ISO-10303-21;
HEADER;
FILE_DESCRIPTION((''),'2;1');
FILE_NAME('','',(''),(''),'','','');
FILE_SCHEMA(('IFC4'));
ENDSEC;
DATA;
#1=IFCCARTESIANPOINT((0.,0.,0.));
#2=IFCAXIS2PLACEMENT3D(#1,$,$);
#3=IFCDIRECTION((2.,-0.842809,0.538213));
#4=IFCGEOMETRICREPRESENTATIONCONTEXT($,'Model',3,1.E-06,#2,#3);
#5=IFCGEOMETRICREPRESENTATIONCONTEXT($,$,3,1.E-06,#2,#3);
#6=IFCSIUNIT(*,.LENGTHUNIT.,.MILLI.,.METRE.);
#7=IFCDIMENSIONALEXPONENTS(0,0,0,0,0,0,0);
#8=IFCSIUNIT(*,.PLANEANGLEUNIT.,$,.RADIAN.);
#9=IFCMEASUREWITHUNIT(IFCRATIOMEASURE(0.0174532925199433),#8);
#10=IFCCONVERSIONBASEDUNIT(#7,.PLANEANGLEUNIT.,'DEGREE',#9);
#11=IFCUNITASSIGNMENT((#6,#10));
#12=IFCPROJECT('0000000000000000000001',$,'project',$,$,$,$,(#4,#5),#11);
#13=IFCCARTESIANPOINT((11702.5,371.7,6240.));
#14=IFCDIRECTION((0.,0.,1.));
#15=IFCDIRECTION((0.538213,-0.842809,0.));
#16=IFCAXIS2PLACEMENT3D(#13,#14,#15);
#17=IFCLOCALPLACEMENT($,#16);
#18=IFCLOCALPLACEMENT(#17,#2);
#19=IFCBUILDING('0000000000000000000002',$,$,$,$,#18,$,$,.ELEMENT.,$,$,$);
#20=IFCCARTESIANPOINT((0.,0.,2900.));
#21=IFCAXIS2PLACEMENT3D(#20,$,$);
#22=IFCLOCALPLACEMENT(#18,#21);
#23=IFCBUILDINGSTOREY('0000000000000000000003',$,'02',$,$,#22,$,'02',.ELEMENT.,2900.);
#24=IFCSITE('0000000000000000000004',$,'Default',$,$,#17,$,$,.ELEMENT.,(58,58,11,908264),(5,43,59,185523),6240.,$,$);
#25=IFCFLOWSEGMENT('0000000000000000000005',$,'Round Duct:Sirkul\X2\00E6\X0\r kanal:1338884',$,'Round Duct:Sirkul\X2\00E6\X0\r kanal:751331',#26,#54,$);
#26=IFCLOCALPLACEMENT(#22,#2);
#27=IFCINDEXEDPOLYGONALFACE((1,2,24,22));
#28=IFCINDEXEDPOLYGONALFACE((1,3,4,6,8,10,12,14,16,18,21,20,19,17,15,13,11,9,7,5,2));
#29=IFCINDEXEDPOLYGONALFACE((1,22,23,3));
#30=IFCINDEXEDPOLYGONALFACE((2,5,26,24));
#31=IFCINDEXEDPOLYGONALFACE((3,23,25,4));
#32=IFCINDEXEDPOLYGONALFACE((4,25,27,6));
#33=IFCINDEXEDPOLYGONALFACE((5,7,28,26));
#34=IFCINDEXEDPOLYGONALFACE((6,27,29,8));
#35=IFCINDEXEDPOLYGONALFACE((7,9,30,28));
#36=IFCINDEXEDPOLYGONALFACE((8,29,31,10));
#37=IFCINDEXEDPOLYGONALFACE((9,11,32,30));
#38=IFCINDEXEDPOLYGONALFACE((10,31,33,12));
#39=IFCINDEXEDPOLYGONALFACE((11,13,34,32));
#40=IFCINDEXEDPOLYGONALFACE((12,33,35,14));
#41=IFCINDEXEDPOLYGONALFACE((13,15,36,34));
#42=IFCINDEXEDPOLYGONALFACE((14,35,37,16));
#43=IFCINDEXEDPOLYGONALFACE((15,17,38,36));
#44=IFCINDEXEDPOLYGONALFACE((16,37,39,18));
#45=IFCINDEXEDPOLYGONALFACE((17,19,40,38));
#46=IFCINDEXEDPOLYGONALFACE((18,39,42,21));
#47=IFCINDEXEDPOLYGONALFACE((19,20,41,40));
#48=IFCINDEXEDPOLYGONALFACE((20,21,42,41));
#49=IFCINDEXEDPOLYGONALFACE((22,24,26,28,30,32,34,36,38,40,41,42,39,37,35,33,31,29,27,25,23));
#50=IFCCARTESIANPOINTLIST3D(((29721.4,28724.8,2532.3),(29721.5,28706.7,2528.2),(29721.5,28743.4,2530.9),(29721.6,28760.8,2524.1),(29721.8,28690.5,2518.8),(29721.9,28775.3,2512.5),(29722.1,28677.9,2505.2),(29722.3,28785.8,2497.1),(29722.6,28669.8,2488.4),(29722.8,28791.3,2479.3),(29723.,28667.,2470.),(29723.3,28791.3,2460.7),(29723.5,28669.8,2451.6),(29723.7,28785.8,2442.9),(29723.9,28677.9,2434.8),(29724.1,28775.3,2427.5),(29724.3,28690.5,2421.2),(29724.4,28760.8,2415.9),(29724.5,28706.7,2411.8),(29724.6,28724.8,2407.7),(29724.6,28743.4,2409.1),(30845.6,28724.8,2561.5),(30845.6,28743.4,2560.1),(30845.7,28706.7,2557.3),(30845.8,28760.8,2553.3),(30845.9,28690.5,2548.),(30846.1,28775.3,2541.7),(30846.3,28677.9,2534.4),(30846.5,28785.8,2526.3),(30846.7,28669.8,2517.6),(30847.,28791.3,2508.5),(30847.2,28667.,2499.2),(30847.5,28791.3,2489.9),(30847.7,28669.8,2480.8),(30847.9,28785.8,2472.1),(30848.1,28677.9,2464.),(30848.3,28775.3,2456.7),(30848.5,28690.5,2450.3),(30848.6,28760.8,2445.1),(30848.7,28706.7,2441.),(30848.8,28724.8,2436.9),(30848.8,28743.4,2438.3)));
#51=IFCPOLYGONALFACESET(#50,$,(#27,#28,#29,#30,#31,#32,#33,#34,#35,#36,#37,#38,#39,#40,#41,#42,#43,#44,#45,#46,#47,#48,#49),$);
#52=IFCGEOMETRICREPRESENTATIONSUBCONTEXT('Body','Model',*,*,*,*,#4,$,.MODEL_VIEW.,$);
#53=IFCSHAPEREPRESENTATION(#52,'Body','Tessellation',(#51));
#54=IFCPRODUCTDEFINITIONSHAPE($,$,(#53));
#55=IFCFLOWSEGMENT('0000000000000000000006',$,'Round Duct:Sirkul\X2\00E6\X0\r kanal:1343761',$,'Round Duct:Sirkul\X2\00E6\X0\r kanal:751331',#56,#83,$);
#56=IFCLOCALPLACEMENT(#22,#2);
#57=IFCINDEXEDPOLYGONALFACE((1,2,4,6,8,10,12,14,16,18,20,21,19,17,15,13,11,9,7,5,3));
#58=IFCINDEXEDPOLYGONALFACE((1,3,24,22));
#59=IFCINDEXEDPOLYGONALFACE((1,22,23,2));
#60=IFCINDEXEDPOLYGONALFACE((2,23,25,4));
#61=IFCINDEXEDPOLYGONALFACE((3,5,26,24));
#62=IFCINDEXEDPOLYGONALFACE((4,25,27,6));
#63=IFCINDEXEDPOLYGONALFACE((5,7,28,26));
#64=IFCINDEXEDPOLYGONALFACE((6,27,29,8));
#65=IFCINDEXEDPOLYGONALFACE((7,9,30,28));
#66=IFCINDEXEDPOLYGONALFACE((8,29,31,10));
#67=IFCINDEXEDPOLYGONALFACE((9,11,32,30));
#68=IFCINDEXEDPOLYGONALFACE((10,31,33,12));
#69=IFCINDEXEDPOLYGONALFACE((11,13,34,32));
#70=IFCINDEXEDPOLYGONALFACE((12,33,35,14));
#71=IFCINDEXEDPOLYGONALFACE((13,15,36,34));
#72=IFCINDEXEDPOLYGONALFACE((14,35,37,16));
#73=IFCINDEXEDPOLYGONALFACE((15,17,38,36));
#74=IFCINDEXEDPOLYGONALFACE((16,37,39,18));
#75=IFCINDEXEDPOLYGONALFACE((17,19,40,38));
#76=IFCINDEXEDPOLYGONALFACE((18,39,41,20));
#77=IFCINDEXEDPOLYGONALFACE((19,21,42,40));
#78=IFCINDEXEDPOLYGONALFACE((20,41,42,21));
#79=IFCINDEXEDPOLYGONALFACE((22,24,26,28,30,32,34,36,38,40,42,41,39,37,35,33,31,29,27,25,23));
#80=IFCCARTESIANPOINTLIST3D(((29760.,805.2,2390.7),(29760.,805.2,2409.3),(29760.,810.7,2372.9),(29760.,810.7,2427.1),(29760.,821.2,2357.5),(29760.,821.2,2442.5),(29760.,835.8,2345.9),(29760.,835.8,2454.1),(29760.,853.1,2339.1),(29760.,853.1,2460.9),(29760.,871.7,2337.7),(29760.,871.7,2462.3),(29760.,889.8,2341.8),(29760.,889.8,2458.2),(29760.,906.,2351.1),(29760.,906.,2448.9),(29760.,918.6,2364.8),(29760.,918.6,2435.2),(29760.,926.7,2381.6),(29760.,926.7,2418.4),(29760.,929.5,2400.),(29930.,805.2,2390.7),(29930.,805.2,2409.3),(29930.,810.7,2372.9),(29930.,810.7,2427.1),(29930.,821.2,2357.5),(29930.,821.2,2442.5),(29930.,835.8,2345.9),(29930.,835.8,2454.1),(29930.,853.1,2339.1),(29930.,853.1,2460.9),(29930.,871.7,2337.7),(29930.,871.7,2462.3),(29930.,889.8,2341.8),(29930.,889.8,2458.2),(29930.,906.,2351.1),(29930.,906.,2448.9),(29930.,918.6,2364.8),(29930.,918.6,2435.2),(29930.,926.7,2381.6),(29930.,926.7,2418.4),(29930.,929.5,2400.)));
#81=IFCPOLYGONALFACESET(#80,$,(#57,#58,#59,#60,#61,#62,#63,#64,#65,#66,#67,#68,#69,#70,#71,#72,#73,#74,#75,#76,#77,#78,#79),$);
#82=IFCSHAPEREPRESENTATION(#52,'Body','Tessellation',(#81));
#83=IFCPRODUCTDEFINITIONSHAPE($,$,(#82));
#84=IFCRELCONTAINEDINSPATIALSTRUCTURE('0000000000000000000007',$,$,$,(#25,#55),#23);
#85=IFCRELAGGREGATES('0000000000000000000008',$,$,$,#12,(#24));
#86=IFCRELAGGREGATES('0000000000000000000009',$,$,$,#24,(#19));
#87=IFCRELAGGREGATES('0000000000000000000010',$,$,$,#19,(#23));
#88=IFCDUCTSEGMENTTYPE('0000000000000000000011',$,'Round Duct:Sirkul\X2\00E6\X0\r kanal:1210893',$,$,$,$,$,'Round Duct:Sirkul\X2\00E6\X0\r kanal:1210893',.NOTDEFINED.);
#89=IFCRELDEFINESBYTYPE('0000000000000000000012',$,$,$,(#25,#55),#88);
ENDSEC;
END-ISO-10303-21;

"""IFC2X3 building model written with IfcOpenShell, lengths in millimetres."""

from ifc_helpers import new_model, entity, si_unit, converted_unit, direction, frame, origin, origin_2d_with_axis, place, context, subcontext, project, spatial, circle, extrude, type_object, element, save


model = new_model("IFC2X3")

# Units and contexts
model_context = context("Model", 3, precision=1e-06, world=origin(), true_north=direction((2.0, -0.842809, 0.538213)))
context_of_model = context(None, 3, precision=1e-06, world=origin(), true_north=direction((2.0, -0.842809, 0.538213)))
body_context = subcontext(model_context, "Body", "Model", "MODEL_VIEW")
ifc_project = project(units=[si_unit("LENGTHUNIT", "METRE", prefix="MILLI"), converted_unit("PLANEANGLEUNIT", "DEGREE", entity("IfcRatioMeasure", 0.0174532925199433), si_unit("PLANEANGLEUNIT", "RADIAN"), dimensions=[0, 0, 0, 0, 0, 0, 0])], contexts=[model_context, context_of_model])

# Site, building, storey
site_placement = place(None, frame((11702.5, 371.7, 6240.0), z_axis=(0.0, 0.0, 1.0), x_axis=(0.538213, -0.842809, 0.0)))
site = spatial("IfcSite", under=ifc_project, at=site_placement, Name="Default", CompositionType="ELEMENT", RefLatitude=(58, 58, 11, 908264), RefLongitude=(5, 43, 59, 185523), RefElevation=6240.0)
building_placement = place(site_placement, origin())
building = spatial("IfcBuilding", under=site, at=building_placement, CompositionType="ELEMENT")
storey_placement = place(building_placement, frame((0.0, 0.0, 2900.0)))
storey = spatial("IfcBuildingStorey", under=building, at=storey_placement, Name="02", LongName="02", CompositionType="ELEMENT", Elevation=2900.0)

# Flow segments
duct_segment_type_1 = type_object("IfcDuctSegmentType", Name="Round Duct:Sirkulær kanal:1210893", ElementType="Round Duct:Sirkulær kanal:1210893", PredefinedType="NOTDEFINED")
flow_segment_1_placement = place(storey_placement, origin())
element("IfcFlowSegment", 1, at=flow_segment_1_placement, inside=storey, type_object=duct_segment_type_1, Name="Round Duct:Sirkulær kanal:1338884", ObjectType="Round Duct:Sirkulær kanal:751331", context=body_context, shape_type="SweptSolid", body=[
    extrude(circle(Radius=62.5, at=origin_2d_with_axis()), frame((29723.0, 28729.5, 2470.0), z_axis=(0.999663, 0.0, 0.025955), x_axis=(0.0, -1.0, 0.0)), (0.0, 0.0, 1.0), 1124.6),
])
flow_segment_2_placement = place(storey_placement, origin())
element("IfcFlowSegment", 2, at=flow_segment_2_placement, inside=storey, type_object=duct_segment_type_1, Name="Round Duct:Sirkulær kanal:1343761", ObjectType="Round Duct:Sirkulær kanal:751331", context=body_context, shape_type="SweptSolid", body=[
    extrude(circle(Radius=62.5, at=origin_2d_with_axis()), frame((29760.0, 867.0, 2400.0), z_axis=(1.0, 0.0, 0.0), x_axis=(0.0, 1.0, 0.0)), (0.0, 0.0, 1.0), 170.0),
])

save(model, "model.ifc")
